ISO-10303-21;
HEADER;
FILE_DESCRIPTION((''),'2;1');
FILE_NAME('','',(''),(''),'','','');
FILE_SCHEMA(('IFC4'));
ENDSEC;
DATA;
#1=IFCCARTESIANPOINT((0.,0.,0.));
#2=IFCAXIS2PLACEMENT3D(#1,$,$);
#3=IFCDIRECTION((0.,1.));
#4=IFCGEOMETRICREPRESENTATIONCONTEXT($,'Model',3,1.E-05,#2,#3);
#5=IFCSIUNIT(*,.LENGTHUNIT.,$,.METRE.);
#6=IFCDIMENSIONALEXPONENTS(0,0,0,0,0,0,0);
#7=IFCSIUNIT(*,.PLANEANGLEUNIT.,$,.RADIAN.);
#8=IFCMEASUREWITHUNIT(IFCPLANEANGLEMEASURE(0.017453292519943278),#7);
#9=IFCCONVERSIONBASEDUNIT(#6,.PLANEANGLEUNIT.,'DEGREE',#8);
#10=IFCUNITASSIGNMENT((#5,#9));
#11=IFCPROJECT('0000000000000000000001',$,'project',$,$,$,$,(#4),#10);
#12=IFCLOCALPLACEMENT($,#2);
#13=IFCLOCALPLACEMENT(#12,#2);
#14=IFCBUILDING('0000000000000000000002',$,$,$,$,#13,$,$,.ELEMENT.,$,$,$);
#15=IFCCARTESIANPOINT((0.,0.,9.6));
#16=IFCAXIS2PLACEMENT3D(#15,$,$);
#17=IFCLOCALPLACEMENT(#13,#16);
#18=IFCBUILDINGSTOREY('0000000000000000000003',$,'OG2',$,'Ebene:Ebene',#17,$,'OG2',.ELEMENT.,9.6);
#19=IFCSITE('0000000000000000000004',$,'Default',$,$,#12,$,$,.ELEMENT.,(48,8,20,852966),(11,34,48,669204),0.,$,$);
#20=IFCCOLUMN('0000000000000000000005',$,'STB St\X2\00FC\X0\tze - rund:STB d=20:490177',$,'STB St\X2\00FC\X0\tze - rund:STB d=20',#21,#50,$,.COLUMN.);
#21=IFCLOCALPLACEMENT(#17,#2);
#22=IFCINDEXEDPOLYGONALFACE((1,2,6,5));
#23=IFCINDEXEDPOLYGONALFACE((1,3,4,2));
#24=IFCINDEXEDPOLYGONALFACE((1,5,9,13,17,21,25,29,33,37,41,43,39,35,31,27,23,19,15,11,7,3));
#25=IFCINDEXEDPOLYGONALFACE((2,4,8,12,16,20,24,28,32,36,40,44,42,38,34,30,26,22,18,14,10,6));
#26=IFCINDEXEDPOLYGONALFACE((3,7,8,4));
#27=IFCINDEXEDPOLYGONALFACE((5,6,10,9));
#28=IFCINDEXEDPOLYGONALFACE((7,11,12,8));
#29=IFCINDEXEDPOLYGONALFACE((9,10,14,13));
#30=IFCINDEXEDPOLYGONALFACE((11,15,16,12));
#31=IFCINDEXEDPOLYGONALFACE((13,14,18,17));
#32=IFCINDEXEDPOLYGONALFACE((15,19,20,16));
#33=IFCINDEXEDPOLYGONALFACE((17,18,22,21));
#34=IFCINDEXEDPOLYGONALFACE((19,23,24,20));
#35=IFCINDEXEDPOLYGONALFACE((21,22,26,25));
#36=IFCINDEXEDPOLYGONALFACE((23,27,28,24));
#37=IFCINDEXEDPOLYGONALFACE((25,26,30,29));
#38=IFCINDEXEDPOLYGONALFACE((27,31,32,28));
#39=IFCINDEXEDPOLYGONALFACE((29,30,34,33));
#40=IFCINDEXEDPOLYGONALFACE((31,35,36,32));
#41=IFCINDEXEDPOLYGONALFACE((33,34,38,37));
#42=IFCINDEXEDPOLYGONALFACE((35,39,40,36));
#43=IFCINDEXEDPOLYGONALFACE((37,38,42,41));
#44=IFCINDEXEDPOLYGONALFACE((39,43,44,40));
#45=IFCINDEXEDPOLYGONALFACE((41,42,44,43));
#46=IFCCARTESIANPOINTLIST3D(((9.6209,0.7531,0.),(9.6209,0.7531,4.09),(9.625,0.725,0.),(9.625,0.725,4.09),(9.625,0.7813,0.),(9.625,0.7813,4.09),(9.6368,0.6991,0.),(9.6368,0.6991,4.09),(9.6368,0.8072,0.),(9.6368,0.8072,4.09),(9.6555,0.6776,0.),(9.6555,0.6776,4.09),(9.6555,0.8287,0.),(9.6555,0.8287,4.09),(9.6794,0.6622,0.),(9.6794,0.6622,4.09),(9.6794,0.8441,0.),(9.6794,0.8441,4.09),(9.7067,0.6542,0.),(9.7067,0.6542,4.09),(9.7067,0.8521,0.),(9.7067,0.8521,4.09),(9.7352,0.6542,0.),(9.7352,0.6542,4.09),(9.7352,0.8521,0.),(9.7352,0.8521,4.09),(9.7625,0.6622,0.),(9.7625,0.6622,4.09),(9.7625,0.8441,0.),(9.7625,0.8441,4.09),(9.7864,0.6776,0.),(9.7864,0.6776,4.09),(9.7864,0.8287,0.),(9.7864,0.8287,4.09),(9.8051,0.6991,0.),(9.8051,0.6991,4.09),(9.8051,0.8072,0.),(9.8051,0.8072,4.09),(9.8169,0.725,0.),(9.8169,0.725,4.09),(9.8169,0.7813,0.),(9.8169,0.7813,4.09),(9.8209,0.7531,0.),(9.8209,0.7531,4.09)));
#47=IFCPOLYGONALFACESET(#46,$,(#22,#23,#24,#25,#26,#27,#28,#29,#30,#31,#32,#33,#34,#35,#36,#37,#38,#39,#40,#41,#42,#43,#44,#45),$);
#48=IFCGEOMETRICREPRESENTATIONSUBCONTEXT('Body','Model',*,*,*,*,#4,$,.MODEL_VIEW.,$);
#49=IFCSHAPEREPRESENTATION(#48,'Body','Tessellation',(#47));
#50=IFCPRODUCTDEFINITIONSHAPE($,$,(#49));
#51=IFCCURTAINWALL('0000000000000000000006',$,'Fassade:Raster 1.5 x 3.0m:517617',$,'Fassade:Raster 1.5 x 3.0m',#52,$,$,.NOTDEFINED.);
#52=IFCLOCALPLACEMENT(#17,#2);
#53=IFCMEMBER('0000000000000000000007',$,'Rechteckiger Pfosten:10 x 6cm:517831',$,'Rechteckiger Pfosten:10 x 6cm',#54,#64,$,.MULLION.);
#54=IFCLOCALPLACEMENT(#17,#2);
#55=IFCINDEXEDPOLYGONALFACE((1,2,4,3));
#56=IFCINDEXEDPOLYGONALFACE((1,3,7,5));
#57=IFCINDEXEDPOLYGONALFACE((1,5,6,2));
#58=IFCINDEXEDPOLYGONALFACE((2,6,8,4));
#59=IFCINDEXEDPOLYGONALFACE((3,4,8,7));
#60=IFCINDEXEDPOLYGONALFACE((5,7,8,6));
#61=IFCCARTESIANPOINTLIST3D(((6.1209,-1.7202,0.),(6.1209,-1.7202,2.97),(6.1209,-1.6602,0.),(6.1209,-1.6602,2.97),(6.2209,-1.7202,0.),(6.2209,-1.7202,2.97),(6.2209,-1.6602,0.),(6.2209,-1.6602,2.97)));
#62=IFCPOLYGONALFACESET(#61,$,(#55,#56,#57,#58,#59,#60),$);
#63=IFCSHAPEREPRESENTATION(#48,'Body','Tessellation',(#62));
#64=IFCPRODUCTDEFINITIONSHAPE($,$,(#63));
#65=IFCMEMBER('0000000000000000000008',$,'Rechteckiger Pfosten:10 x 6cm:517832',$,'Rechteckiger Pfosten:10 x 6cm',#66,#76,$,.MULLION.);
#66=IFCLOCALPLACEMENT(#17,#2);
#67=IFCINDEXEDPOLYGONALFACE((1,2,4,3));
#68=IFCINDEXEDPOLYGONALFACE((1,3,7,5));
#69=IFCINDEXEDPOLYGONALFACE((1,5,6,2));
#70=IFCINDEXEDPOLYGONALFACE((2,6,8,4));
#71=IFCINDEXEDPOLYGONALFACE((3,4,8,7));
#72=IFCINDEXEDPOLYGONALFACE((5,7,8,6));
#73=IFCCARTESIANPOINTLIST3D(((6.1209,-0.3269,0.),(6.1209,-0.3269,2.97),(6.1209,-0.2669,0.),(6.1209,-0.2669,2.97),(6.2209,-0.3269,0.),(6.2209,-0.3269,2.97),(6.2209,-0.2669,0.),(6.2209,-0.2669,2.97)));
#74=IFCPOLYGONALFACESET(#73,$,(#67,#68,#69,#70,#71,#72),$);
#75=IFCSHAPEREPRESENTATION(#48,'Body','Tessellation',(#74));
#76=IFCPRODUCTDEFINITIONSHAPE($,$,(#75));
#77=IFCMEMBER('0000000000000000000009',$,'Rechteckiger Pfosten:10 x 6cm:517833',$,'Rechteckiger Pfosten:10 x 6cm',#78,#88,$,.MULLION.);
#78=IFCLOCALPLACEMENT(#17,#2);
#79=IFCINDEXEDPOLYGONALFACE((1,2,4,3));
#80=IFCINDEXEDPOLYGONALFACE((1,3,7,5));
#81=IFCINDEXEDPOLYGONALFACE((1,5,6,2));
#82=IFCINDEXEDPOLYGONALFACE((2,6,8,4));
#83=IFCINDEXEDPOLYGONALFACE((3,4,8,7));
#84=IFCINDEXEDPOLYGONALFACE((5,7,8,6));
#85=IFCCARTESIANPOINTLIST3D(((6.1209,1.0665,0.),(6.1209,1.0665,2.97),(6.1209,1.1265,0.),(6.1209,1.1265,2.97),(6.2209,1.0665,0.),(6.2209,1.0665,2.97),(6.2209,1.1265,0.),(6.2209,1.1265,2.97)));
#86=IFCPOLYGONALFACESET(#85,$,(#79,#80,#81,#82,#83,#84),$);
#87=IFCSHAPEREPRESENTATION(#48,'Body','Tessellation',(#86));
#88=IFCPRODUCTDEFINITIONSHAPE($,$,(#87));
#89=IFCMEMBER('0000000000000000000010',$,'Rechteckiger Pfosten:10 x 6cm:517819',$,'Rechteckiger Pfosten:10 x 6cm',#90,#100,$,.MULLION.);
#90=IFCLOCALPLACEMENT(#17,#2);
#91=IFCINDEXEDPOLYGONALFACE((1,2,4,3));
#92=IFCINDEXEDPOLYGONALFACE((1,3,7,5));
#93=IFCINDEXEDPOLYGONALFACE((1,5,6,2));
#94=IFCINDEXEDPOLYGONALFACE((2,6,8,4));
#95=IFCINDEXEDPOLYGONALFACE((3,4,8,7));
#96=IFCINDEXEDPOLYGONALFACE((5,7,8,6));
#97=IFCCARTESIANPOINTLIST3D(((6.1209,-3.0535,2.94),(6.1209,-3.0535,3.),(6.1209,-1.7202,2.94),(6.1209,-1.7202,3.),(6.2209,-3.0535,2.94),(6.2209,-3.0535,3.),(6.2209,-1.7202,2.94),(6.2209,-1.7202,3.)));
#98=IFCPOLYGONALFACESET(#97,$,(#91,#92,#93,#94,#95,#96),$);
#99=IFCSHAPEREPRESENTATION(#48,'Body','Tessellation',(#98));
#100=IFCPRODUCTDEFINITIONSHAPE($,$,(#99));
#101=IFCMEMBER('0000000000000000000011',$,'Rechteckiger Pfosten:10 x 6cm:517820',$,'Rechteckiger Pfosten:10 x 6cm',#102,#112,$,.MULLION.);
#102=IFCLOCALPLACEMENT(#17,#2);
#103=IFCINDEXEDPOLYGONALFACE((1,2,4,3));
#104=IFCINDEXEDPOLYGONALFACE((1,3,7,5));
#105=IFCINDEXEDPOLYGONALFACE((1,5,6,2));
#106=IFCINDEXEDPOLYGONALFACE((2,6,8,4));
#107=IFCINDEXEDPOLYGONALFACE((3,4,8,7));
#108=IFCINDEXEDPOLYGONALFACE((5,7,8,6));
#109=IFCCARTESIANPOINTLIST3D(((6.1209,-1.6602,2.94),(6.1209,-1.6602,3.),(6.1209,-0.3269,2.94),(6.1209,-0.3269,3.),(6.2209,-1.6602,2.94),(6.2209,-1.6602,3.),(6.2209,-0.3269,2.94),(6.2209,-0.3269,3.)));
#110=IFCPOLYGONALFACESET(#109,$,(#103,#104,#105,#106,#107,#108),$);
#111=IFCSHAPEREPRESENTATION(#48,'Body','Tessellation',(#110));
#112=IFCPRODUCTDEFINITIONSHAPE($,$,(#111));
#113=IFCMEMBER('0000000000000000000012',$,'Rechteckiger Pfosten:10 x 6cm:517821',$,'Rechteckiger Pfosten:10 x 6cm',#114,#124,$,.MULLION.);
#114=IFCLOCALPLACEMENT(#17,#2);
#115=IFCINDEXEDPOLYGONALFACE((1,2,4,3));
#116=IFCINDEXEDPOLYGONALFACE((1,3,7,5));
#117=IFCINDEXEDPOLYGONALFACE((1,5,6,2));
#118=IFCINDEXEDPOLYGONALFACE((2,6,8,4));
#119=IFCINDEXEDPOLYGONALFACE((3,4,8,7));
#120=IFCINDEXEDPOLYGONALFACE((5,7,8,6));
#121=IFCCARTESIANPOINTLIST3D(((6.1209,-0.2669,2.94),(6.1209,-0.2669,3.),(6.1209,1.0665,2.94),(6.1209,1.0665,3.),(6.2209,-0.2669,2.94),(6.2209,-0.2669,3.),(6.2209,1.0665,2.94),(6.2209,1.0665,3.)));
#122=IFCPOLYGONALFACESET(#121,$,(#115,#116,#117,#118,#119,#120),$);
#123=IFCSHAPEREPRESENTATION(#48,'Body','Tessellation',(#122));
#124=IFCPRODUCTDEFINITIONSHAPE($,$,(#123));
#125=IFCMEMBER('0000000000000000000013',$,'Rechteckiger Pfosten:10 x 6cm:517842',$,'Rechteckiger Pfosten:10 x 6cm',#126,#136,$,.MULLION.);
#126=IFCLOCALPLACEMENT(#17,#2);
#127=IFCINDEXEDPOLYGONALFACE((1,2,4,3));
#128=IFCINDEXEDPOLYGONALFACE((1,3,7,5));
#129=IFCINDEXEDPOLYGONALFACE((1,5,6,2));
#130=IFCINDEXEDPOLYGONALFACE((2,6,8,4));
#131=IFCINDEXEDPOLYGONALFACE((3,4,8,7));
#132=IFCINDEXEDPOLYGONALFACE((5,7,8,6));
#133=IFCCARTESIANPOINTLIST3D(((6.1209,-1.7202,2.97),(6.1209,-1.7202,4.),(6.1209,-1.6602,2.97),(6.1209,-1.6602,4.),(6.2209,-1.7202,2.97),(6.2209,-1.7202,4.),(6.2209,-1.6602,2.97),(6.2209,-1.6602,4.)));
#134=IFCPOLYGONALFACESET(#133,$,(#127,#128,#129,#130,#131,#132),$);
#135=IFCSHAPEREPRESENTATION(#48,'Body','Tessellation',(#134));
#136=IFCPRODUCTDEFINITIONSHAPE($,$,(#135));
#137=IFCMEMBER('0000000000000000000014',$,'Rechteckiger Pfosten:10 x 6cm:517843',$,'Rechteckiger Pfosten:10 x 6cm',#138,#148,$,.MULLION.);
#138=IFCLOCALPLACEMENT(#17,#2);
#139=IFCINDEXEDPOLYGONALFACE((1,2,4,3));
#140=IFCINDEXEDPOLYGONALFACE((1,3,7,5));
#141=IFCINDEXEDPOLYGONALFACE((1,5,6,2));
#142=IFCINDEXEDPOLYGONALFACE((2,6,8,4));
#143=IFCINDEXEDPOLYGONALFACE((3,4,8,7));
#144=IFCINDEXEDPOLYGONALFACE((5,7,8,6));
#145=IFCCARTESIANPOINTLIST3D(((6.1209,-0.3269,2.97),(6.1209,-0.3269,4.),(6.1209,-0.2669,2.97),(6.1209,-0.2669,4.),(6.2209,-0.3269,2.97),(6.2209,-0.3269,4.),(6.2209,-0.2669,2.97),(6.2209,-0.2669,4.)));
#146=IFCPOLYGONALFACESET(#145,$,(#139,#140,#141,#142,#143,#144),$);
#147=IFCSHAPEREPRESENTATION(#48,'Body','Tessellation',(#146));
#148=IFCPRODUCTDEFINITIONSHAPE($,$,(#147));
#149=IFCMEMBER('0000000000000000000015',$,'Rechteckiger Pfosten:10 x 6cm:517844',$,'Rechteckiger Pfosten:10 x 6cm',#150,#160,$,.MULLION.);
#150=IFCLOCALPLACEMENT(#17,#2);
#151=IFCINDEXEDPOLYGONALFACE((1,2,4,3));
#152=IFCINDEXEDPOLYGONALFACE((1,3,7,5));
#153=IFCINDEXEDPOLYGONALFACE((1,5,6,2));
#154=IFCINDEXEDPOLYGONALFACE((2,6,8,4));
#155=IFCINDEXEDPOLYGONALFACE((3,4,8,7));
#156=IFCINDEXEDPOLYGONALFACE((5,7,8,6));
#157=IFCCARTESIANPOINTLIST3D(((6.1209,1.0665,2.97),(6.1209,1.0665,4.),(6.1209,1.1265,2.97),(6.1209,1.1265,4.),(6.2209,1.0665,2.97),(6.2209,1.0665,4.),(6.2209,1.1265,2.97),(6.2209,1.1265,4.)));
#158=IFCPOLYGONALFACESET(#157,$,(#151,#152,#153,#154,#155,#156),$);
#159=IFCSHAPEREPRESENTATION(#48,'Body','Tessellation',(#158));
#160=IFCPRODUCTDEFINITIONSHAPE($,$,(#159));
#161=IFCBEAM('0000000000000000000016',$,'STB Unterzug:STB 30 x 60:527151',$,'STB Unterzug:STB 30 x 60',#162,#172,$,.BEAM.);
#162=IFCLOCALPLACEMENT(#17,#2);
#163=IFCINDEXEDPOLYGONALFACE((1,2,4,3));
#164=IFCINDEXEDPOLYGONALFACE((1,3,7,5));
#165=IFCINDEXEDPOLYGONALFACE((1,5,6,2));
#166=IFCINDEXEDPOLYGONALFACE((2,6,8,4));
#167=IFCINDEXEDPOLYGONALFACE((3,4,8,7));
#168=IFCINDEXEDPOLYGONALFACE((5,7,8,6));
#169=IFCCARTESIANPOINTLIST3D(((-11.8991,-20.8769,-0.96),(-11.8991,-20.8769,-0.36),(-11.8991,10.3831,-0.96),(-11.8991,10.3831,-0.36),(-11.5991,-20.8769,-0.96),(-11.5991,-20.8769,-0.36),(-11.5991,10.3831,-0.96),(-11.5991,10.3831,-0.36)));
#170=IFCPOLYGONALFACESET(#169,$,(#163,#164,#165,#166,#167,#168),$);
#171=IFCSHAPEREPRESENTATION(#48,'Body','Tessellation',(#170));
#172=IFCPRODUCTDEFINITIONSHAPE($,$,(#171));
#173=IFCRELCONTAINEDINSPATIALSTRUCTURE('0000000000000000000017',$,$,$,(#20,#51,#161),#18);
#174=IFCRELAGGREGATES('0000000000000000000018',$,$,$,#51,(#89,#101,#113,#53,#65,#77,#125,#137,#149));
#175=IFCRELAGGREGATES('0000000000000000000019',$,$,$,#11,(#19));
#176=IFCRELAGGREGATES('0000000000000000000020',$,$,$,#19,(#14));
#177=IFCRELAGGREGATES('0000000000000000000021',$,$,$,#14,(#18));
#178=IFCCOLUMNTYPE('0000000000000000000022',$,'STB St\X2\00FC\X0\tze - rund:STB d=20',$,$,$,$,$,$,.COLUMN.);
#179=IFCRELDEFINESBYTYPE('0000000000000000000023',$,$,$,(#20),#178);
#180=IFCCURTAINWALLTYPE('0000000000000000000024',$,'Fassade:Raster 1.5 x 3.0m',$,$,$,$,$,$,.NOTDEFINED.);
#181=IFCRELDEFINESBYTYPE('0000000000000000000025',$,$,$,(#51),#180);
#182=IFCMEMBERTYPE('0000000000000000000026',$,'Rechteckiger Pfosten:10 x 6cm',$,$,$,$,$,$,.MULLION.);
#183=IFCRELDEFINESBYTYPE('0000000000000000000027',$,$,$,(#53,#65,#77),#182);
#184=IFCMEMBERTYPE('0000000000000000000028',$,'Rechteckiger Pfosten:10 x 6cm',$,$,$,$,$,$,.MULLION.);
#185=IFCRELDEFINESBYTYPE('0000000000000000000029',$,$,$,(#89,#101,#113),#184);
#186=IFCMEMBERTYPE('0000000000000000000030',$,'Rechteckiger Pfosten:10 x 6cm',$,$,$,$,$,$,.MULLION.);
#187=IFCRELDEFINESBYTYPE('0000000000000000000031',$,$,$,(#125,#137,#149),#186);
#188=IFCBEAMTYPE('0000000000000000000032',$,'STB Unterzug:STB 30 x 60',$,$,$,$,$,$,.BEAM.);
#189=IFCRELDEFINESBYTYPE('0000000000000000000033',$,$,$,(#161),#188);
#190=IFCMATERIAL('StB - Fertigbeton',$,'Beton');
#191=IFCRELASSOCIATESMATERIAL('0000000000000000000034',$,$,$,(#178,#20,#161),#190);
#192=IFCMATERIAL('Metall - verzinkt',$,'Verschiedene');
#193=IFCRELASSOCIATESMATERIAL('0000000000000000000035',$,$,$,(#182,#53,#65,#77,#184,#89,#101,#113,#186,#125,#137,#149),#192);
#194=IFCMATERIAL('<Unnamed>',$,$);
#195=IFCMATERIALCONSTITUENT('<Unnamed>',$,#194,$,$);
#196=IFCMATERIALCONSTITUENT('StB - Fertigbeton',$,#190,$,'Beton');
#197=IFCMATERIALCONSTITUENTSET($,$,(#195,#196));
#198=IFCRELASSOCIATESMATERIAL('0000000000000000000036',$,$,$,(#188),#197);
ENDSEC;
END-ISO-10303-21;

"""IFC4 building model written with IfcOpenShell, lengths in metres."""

from ifc_helpers import new_model, entity, si_unit, converted_unit, direction, frame, origin, place, context, subcontext, project, spatial, arc, indexed_curve, outline, extrude, source, transform, mapped, material, constituent, constituent_set, type_object, type_shapes, element, aggregate, save


model = new_model("IFC4")

# Units and contexts
model_context = context("Model", 3, precision=1e-05, world=origin(), true_north=direction((0.0, 1.0)))
body_context = subcontext(model_context, "Body", "Model", "MODEL_VIEW")
ifc_project = project(units=[si_unit("LENGTHUNIT", "METRE"), converted_unit("PLANEANGLEUNIT", "DEGREE", entity("IfcPlaneAngleMeasure", 0.017453292519943278), si_unit("PLANEANGLEUNIT", "RADIAN"), dimensions=[0, 0, 0, 0, 0, 0, 0])], contexts=[model_context])

# Site, building, storey
site_placement = place(None, origin())
site = spatial("IfcSite", under=ifc_project, at=site_placement, Name="Default", CompositionType="ELEMENT", RefLatitude=(48, 8, 20, 852966), RefLongitude=(11, 34, 48, 669204), RefElevation=0.0)
building_placement = place(site_placement, origin())
building = spatial("IfcBuilding", under=site, at=building_placement, CompositionType="ELEMENT")
storey_placement = place(building_placement, frame((0.0, 0.0, 9.6)))
storey = spatial("IfcBuildingStorey", under=building, at=storey_placement, Name="OG2", ObjectType="Ebene:Ebene", LongName="OG2", CompositionType="ELEMENT", Elevation=9.6)

# Column
ifc_material_1 = material(Name="StB - Fertigbeton", Category="Beton")
column_type = type_object("IfcColumnType", Name="STB Stütze - rund:STB d=20", PredefinedType="COLUMN", material=ifc_material_1)
shared_shape_1 = source(origin(), body_context, "Body", "SweptSolid", [
    extrude(outline(indexed_curve([(-0.1, 0.0), (0.0, -0.1), (0.1, 0.0), (0.0, 0.1)], segments=[arc(1, 2, 3), arc(3, 4, 1)], self_intersect=False)), frame((0.0, 0.0, 9.6)), (0.0, 0.0, 1.0), 4.09),
])
type_shapes(column_type, [shared_shape_1])
column_placement = place(storey_placement, frame((9.7209, 0.7531, -9.6)))
element("IfcColumn", 1, at=column_placement, inside=storey, type_object=column_type, material=ifc_material_1, Name="STB Stütze - rund:STB d=20:490177", ObjectType="STB Stütze - rund:STB d=20", PredefinedType="COLUMN", context=body_context, shape_type="MappedRepresentation", body=[
    mapped(shared_shape_1, transform((0.0, 0.0, 0.0), scale=1.0)),
])

# Curtain wall, members
curtain_wall_type = type_object("IfcCurtainWallType", Name="Fassade:Raster 1.5 x 3.0m", PredefinedType="NOTDEFINED")
curtain_wall_placement = place(storey_placement, frame((0.0, 0.0, -9.6)))
curtain_wall = element("IfcCurtainWall", 2, at=curtain_wall_placement, inside=storey, type_object=curtain_wall_type, Name="Fassade:Raster 1.5 x 3.0m:517617", ObjectType="Fassade:Raster 1.5 x 3.0m", PredefinedType="NOTDEFINED")
ifc_material_2 = material(Name="Metall - verzinkt", Category="Verschiedene")
member_type_1 = type_object("IfcMemberType", Name="Rechteckiger Pfosten:10 x 6cm", PredefinedType="MULLION", material=ifc_material_2)
shared_shape_2 = source(origin(), body_context, "Body", "SweptSolid", [
    extrude(outline(indexed_curve([(-0.03, -0.05), (0.03, -0.05), (0.03, 0.05), (-0.03, 0.05), (-0.03, -0.05)], self_intersect=False)), frame((0.0, 0.0, -2.97), z_axis=(0.0, 0.0, 1.0), x_axis=(-1.0, 0.0, 0.0)), (0.0, 0.0, 1.0), 2.97),
])
type_shapes(member_type_1, [shared_shape_2])
member_1_placement = place(curtain_wall_placement, frame((6.1709, -1.6902, 9.6), z_axis=(0.0, 0.0, -1.0), x_axis=(0.0, 1.0, 0.0)))
member_1 = element("IfcMember", 3, at=member_1_placement, type_object=member_type_1, material=ifc_material_2, Name="Rechteckiger Pfosten:10 x 6cm:517831", ObjectType="Rechteckiger Pfosten:10 x 6cm", PredefinedType="MULLION", context=body_context, shape_type="MappedRepresentation", body=[
    mapped(shared_shape_2, transform((0.0, 0.0, 0.0), scale=1.0)),
])
member_2_placement = place(curtain_wall_placement, frame((6.1709, -0.2969, 9.6), z_axis=(0.0, 0.0, -1.0), x_axis=(0.0, 1.0, 0.0)))
member_2 = element("IfcMember", 4, at=member_2_placement, type_object=member_type_1, material=ifc_material_2, Name="Rechteckiger Pfosten:10 x 6cm:517832", ObjectType="Rechteckiger Pfosten:10 x 6cm", PredefinedType="MULLION", context=body_context, shape_type="MappedRepresentation", body=[
    mapped(shared_shape_2, transform((0.0, 0.0, 0.0), scale=1.0)),
])
member_3_placement = place(curtain_wall_placement, frame((6.1709, 1.0965, 9.6), z_axis=(0.0, 0.0, -1.0), x_axis=(0.0, 1.0, 0.0)))
member_3 = element("IfcMember", 5, at=member_3_placement, type_object=member_type_1, material=ifc_material_2, Name="Rechteckiger Pfosten:10 x 6cm:517833", ObjectType="Rechteckiger Pfosten:10 x 6cm", PredefinedType="MULLION", context=body_context, shape_type="MappedRepresentation", body=[
    mapped(shared_shape_2, transform((0.0, 0.0, 0.0), scale=1.0)),
])
member_type_2 = type_object("IfcMemberType", Name="Rechteckiger Pfosten:10 x 6cm", PredefinedType="MULLION", material=ifc_material_2)
shared_shape_3 = source(origin(), body_context, "Body", "SweptSolid", [
    extrude(outline(indexed_curve([(-0.03, -0.05), (0.03, -0.05), (0.03, 0.05), (-0.03, 0.05), (-0.03, -0.05)], self_intersect=False)), frame((0.0, 0.0, -1.3333), z_axis=(0.0, 0.0, 1.0), x_axis=(-1.0, 0.0, 0.0)), (0.0, 0.0, 1.0), 1.3333),
])
type_shapes(member_type_2, [shared_shape_3])
member_4_placement = place(curtain_wall_placement, frame((6.1709, -1.7202, 12.57), z_axis=(0.0, 1.0, 0.0), x_axis=(0.0, 0.0, 1.0)))
member_4 = element("IfcMember", 6, at=member_4_placement, type_object=member_type_2, material=ifc_material_2, Name="Rechteckiger Pfosten:10 x 6cm:517819", ObjectType="Rechteckiger Pfosten:10 x 6cm", PredefinedType="MULLION", context=body_context, shape_type="MappedRepresentation", body=[
    mapped(shared_shape_3, transform((0.0, 0.0, 0.0), scale=1.0)),
])
member_5_placement = place(curtain_wall_placement, frame((6.1709, -0.3269, 12.57), z_axis=(0.0, 1.0, 0.0), x_axis=(0.0, 0.0, 1.0)))
member_5 = element("IfcMember", 7, at=member_5_placement, type_object=member_type_2, material=ifc_material_2, Name="Rechteckiger Pfosten:10 x 6cm:517820", ObjectType="Rechteckiger Pfosten:10 x 6cm", PredefinedType="MULLION", context=body_context, shape_type="MappedRepresentation", body=[
    mapped(shared_shape_3, transform((0.0, 0.0, 0.0), scale=1.0)),
])
member_6_placement = place(curtain_wall_placement, frame((6.1709, 1.0665, 12.57), z_axis=(0.0, 1.0, 0.0), x_axis=(0.0, 0.0, 1.0)))
member_6 = element("IfcMember", 8, at=member_6_placement, type_object=member_type_2, material=ifc_material_2, Name="Rechteckiger Pfosten:10 x 6cm:517821", ObjectType="Rechteckiger Pfosten:10 x 6cm", PredefinedType="MULLION", context=body_context, shape_type="MappedRepresentation", body=[
    mapped(shared_shape_3, transform((0.0, 0.0, 0.0), scale=1.0)),
])
member_type_3 = type_object("IfcMemberType", Name="Rechteckiger Pfosten:10 x 6cm", PredefinedType="MULLION", material=ifc_material_2)
shared_shape_4 = source(origin(), body_context, "Body", "SweptSolid", [
    extrude(outline(indexed_curve([(-0.03, -0.05), (0.03, -0.05), (0.03, 0.05), (-0.03, 0.05), (-0.03, -0.05)], self_intersect=False)), frame((0.0, 0.0, -1.03), z_axis=(0.0, 0.0, 1.0), x_axis=(-1.0, 0.0, 0.0)), (0.0, 0.0, 1.0), 1.03),
])
type_shapes(member_type_3, [shared_shape_4])
member_7_placement = place(curtain_wall_placement, frame((6.1709, -1.6902, 12.57), z_axis=(0.0, 0.0, -1.0), x_axis=(0.0, 1.0, 0.0)))
member_7 = element("IfcMember", 9, at=member_7_placement, type_object=member_type_3, material=ifc_material_2, Name="Rechteckiger Pfosten:10 x 6cm:517842", ObjectType="Rechteckiger Pfosten:10 x 6cm", PredefinedType="MULLION", context=body_context, shape_type="MappedRepresentation", body=[
    mapped(shared_shape_4, transform((0.0, 0.0, 0.0), scale=1.0)),
])
member_8_placement = place(curtain_wall_placement, frame((6.1709, -0.2969, 12.57), z_axis=(0.0, 0.0, -1.0), x_axis=(0.0, 1.0, 0.0)))
member_8 = element("IfcMember", 10, at=member_8_placement, type_object=member_type_3, material=ifc_material_2, Name="Rechteckiger Pfosten:10 x 6cm:517843", ObjectType="Rechteckiger Pfosten:10 x 6cm", PredefinedType="MULLION", context=body_context, shape_type="MappedRepresentation", body=[
    mapped(shared_shape_4, transform((0.0, 0.0, 0.0), scale=1.0)),
])
member_9_placement = place(curtain_wall_placement, frame((6.1709, 1.0965, 12.57), z_axis=(0.0, 0.0, -1.0), x_axis=(0.0, 1.0, 0.0)))
member_9 = element("IfcMember", 11, at=member_9_placement, type_object=member_type_3, material=ifc_material_2, Name="Rechteckiger Pfosten:10 x 6cm:517844", ObjectType="Rechteckiger Pfosten:10 x 6cm", PredefinedType="MULLION", context=body_context, shape_type="MappedRepresentation", body=[
    mapped(shared_shape_4, transform((0.0, 0.0, 0.0), scale=1.0)),
])

# Beam
ifc_material_3 = material(Name="<Unnamed>")
ifc_constituent_1 = constituent(ifc_material_3, Name="<Unnamed>")
ifc_constituent_2 = constituent(ifc_material_1, Name="StB - Fertigbeton", Category="Beton")
ifc_constituent_set_1 = constituent_set(constituents=[ifc_constituent_1, ifc_constituent_2])
beam_type = type_object("IfcBeamType", Name="STB Unterzug:STB 30 x 60", PredefinedType="BEAM", material=ifc_constituent_set_1)
shared_shape_5 = source(origin(), body_context, "Body", "SweptSolid", [
    extrude(outline(indexed_curve([(-0.15, -0.3), (0.15, -0.3), (0.15, 0.3), (-0.15, 0.3), (-0.15, -0.3)], self_intersect=False)), frame((-11.7491, 10.3831, 8.94), z_axis=(0.0, -1.0, 0.0), x_axis=(-1.0, 0.0, 0.0)), (0.0, 0.0, 1.0), 31.26),
])
type_shapes(beam_type, [shared_shape_5])
beam_placement = place(storey_placement, frame((0.0, 0.0, -9.6)))
element("IfcBeam", 12, at=beam_placement, inside=storey, type_object=beam_type, material=ifc_material_1, Name="STB Unterzug:STB 30 x 60:527151", ObjectType="STB Unterzug:STB 30 x 60", PredefinedType="BEAM", context=body_context, shape_type="MappedRepresentation", body=[
    mapped(shared_shape_5, transform((0.0, 0.0, 0.0), scale=1.0)),
])

aggregate(curtain_wall, [member_4, member_5, member_6, member_1, member_2, member_3, member_7, member_8, member_9])

save(model, "model.ifc")
